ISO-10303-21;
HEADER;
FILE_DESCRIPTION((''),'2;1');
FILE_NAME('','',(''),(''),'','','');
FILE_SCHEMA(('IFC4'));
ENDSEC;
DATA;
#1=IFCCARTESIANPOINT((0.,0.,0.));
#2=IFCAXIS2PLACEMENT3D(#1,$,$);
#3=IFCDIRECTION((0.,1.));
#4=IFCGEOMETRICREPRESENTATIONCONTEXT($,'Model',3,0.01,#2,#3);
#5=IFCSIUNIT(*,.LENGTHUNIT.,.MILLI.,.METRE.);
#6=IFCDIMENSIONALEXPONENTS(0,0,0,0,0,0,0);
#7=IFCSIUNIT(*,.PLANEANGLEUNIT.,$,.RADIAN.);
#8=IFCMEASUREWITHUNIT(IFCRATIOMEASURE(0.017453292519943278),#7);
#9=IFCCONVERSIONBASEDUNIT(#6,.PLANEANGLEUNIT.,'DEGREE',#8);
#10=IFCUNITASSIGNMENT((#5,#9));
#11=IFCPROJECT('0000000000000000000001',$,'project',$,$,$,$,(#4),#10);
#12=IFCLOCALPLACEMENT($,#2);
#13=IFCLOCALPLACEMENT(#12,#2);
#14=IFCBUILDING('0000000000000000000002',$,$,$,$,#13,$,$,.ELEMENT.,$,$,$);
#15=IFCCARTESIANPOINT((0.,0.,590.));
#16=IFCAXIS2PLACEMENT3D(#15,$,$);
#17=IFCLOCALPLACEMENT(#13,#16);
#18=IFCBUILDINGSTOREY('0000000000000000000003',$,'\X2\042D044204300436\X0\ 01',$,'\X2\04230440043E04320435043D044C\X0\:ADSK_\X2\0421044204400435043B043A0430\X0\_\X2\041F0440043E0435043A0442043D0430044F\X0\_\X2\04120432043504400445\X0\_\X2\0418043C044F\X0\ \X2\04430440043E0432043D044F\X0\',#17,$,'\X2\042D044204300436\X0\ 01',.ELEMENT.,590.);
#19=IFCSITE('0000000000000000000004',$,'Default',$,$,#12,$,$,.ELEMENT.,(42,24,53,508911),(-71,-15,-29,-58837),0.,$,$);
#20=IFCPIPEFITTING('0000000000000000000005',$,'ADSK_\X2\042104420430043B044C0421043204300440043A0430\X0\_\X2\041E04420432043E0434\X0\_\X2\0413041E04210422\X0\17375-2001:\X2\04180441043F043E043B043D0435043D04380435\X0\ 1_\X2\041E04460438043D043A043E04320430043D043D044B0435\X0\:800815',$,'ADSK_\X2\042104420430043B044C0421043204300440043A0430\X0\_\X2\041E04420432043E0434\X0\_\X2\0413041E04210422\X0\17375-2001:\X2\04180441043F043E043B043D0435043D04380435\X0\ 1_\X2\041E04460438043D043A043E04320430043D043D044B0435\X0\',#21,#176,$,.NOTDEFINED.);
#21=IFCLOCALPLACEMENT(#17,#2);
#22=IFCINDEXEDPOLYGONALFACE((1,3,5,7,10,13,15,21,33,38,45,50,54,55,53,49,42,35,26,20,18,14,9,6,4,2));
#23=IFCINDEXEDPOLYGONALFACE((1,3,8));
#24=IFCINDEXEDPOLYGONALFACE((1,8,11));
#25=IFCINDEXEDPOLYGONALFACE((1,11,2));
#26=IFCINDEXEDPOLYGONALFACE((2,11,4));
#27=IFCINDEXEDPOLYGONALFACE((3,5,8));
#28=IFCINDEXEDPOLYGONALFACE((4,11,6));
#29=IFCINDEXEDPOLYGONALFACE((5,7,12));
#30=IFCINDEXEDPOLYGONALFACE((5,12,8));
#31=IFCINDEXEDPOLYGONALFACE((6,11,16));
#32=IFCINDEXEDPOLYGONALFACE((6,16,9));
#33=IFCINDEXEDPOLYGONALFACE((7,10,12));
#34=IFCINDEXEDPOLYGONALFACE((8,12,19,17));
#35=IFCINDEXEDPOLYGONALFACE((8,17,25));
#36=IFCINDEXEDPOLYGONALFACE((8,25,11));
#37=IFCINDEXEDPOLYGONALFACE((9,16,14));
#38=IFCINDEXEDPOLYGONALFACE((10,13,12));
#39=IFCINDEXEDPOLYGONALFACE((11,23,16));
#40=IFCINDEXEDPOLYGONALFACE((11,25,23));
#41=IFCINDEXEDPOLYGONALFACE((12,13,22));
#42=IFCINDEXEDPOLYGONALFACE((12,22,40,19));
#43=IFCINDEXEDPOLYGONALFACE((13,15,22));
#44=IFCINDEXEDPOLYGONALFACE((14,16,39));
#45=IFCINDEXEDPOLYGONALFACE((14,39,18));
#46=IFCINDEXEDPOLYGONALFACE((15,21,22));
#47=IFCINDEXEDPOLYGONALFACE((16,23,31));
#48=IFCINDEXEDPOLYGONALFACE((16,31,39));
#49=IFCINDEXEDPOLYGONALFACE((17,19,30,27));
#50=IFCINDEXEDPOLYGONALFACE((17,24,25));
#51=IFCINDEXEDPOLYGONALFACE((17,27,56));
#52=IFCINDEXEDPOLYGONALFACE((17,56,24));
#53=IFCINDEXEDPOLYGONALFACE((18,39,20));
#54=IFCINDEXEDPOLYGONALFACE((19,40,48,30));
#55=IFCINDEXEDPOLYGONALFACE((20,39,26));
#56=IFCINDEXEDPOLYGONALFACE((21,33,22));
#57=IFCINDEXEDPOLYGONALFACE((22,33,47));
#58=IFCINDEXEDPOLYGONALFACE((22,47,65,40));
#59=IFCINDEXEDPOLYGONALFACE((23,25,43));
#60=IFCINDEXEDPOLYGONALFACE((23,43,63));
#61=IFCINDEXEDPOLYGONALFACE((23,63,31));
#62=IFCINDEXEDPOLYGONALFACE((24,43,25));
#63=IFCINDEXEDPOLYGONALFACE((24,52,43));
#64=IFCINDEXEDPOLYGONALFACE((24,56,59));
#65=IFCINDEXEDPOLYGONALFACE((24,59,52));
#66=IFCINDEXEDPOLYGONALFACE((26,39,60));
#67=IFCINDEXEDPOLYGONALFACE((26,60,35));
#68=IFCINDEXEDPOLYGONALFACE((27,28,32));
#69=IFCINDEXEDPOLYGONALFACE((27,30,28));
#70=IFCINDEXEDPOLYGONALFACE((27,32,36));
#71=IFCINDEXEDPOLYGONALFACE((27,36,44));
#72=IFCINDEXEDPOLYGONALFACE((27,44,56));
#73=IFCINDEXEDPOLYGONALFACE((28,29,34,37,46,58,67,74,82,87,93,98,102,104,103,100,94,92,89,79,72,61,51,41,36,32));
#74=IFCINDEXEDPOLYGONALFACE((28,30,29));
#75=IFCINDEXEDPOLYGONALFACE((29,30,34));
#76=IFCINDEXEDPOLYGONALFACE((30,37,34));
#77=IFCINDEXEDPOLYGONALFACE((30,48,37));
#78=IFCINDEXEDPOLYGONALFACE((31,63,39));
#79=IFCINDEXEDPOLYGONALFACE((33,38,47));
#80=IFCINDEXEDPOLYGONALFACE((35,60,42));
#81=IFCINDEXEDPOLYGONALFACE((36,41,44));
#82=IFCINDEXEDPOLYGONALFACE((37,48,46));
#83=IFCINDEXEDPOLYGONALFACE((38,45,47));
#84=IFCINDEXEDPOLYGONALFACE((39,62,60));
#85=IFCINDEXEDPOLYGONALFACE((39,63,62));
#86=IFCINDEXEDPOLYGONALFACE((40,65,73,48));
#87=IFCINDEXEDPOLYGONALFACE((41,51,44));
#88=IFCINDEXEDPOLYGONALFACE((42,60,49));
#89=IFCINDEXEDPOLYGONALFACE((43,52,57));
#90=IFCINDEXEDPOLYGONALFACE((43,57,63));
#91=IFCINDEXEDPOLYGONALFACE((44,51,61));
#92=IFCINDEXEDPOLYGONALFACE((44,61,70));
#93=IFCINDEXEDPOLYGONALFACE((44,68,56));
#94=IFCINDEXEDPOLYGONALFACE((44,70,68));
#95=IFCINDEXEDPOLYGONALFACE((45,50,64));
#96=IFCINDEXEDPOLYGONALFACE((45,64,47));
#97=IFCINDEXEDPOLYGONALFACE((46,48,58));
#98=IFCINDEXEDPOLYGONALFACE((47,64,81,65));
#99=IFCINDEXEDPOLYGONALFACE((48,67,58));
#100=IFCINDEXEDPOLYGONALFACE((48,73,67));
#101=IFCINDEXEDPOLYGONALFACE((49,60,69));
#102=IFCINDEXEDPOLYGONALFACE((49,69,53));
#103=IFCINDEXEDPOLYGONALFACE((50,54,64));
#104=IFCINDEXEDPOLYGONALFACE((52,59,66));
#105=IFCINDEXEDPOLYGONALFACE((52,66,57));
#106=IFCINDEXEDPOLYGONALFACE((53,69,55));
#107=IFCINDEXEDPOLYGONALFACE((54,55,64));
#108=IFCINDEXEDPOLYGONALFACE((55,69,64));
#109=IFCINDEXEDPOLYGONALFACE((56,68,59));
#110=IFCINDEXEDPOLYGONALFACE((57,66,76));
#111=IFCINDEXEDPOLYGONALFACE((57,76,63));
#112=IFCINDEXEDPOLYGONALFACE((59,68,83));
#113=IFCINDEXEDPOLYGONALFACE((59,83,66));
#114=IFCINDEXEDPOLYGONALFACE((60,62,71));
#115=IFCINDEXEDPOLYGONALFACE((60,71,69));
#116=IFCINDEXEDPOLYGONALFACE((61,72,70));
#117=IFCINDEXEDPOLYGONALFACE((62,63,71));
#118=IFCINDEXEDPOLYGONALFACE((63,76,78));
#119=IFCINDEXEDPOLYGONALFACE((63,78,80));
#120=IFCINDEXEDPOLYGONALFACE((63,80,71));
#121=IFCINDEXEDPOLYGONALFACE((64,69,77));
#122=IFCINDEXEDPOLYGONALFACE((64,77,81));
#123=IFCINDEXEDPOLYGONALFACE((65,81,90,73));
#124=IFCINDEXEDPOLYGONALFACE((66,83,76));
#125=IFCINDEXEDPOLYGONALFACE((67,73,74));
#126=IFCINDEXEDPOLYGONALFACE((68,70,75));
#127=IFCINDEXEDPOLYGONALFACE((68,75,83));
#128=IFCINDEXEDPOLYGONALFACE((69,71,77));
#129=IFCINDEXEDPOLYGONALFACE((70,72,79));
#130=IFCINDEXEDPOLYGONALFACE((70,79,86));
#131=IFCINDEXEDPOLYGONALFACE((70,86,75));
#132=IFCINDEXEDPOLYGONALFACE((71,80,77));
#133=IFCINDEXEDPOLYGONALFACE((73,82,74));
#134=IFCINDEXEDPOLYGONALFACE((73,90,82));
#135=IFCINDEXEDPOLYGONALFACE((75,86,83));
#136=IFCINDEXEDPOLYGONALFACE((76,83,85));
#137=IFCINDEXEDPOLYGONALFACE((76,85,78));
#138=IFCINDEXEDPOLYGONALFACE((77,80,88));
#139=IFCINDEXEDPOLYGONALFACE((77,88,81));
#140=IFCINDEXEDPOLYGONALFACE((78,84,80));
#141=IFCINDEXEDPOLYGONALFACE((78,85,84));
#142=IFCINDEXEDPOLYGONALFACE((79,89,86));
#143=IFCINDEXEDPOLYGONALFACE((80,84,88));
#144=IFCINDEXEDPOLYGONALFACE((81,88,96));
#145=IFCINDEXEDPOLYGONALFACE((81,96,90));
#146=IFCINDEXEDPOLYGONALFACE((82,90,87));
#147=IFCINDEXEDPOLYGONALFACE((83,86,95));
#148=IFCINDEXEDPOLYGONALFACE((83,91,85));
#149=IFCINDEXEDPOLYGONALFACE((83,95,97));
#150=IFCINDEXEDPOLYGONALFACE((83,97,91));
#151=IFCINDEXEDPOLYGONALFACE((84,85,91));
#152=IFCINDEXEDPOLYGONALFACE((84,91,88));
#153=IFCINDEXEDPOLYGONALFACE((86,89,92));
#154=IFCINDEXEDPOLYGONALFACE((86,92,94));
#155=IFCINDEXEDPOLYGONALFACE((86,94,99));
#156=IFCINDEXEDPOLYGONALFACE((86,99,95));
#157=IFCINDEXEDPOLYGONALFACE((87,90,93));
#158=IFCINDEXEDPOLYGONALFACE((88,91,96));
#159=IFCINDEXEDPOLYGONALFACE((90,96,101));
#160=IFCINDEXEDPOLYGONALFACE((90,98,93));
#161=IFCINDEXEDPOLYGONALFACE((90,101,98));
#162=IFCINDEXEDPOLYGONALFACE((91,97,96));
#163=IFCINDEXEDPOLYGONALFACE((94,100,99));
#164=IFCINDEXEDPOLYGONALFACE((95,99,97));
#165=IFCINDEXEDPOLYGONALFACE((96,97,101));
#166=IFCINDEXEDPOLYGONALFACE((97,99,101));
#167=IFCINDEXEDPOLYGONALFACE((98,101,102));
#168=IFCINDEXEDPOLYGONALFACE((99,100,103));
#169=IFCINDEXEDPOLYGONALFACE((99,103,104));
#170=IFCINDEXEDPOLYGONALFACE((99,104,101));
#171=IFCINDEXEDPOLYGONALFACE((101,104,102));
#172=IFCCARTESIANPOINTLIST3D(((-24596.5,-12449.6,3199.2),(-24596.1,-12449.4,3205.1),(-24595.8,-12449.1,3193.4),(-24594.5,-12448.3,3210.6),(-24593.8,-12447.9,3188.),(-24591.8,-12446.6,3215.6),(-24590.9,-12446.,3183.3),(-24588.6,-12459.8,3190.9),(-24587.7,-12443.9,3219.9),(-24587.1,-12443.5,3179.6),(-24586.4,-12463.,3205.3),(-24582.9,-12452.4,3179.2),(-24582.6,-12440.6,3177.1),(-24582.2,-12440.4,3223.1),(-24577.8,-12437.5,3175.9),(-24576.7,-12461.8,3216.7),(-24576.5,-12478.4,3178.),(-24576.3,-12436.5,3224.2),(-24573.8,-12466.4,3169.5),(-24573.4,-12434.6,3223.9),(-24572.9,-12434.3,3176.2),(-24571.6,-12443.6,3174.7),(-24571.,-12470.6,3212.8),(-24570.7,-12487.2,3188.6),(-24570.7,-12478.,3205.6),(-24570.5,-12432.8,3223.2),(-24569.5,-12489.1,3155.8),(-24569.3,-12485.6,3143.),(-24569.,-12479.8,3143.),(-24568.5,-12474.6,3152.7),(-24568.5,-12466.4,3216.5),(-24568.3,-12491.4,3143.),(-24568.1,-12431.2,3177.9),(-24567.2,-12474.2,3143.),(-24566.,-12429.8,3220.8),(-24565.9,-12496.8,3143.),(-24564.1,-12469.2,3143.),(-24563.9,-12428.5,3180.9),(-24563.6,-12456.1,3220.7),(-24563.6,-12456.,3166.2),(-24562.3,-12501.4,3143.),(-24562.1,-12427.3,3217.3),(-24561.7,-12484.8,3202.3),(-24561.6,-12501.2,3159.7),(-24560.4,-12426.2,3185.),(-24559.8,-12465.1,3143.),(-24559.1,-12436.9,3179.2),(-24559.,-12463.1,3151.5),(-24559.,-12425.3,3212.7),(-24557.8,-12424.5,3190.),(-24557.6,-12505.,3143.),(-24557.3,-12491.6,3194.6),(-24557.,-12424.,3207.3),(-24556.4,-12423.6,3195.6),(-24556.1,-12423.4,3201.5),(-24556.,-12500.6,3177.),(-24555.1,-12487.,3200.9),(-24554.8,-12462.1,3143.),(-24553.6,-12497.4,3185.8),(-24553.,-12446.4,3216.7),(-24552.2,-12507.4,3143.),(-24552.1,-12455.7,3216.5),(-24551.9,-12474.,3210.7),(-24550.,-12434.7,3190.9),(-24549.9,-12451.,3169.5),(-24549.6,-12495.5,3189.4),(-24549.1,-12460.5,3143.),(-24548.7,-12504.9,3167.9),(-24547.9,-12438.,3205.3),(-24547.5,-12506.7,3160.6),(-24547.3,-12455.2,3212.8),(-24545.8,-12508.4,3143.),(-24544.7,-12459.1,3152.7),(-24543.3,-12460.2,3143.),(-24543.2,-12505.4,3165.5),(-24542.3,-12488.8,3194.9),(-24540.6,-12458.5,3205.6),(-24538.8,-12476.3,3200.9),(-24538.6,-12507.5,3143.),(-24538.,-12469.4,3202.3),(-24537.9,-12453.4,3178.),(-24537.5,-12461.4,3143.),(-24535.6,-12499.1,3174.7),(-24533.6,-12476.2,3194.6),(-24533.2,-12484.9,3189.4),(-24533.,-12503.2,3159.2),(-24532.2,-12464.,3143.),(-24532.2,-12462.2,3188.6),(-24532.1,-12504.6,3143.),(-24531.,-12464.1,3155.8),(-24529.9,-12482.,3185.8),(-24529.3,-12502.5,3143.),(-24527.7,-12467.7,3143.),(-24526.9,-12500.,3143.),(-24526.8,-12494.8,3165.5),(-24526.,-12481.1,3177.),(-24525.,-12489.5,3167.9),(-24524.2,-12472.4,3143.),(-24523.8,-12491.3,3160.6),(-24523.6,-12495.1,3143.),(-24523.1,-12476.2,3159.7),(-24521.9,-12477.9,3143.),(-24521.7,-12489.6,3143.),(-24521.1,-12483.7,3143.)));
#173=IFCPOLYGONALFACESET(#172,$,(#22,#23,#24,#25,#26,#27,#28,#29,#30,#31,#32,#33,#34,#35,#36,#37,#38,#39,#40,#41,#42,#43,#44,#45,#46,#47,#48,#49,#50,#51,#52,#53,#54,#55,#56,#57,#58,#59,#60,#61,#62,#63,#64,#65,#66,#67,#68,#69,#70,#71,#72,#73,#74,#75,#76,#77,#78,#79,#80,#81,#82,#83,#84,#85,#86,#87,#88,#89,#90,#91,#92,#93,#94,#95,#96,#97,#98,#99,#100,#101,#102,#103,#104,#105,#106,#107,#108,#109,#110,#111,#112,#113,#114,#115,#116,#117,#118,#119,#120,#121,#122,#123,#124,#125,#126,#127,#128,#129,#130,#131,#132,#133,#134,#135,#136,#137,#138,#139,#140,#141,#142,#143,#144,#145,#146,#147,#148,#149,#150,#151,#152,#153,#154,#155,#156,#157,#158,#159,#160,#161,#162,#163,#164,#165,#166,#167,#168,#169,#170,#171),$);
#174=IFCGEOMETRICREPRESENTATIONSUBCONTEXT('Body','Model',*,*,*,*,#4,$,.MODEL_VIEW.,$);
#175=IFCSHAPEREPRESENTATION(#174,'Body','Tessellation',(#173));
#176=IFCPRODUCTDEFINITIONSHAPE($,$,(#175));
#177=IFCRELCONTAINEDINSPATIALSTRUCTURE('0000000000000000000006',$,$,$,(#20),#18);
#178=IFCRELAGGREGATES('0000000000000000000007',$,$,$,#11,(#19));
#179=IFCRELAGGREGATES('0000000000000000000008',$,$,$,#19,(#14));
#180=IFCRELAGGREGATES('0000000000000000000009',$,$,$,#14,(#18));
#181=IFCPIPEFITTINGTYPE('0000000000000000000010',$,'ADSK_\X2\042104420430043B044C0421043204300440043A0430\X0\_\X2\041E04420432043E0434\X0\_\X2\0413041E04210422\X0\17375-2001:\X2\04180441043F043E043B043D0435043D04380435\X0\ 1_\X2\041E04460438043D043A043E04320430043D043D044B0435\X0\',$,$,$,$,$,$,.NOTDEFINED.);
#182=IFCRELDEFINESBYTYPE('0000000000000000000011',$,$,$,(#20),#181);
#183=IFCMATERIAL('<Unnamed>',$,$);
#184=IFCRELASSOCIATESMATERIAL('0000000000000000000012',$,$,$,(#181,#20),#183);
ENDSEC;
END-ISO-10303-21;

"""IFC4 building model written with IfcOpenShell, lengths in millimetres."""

from ifc_helpers import new_model, entity, si_unit, converted_unit, direction, frame, origin, place, context, subcontext, project, spatial, source, transform, mapped, material, type_object, type_shapes, element, save


model = new_model("IFC4")

# Units and contexts
model_context = context("Model", 3, precision=0.01, world=origin(), true_north=direction((0.0, 1.0)))
body_context = subcontext(model_context, "Body", "Model", "MODEL_VIEW")
ifc_project = project(units=[si_unit("LENGTHUNIT", "METRE", prefix="MILLI"), converted_unit("PLANEANGLEUNIT", "DEGREE", entity("IfcRatioMeasure", 0.017453292519943278), si_unit("PLANEANGLEUNIT", "RADIAN"), dimensions=[0, 0, 0, 0, 0, 0, 0])], contexts=[model_context])

# Site, building, storey
site_placement = place(None, origin())
site = spatial("IfcSite", under=ifc_project, at=site_placement, Name="Default", CompositionType="ELEMENT", RefLatitude=(42, 24, 53, 508911), RefLongitude=(-71, -15, -29, -58837), RefElevation=0.0)
building_placement = place(site_placement, origin())
building = spatial("IfcBuilding", under=site, at=building_placement, CompositionType="ELEMENT")
storey_placement = place(building_placement, frame((0.0, 0.0, 590.0)))
storey = spatial("IfcBuildingStorey", under=building, at=storey_placement, Name="Этаж 01", ObjectType="Уровень:ADSK_Стрелка_Проектная_Вверх_Имя уровня", LongName="Этаж 01", CompositionType="ELEMENT", Elevation=590.0)

# Shared definitions
ifc_material_1 = material(Name="<Unnamed>")

# Pipe fitting
pipe_fitting_type = type_object("IfcPipeFittingType", Name="ADSK_СтальСварка_Отвод_ГОСТ17375-2001:Исполнение 1_Оцинкованные", PredefinedType="NOTDEFINED", material=ifc_material_1)
ifc_direction = entity("IfcDirection", [0.0, 0.0, 1.0])
trimmed_curve = entity("IfcTrimmedCurve", entity("IfcCircle", entity("IfcAxis2Placement2D", entity("IfcCartesianPoint", [-57.0, 0.0]), entity("IfcDirection", [0.0, 1.0])), 57.0), [entity("IfcParameterValue", 270.0)], [entity("IfcParameterValue", 0.0)], True, "PARAMETER")
shared_shape_1 = source(origin(), body_context, "Body", "AdvancedSweptSolid", [
    entity("IfcSurfaceCurveSweptAreaSolid", entity("IfcCircleProfileDef", "AREA", None, entity("IfcAxis2Placement2D", entity("IfcCartesianPoint", [0.0, 0.0]), entity("IfcDirection", [1.0, 0.0])), 24.1), entity("IfcAxis2Placement3D", entity("IfcCartesianPoint", [-57.0, 0.0, 0.0]), ifc_direction, entity("IfcDirection", [0.0, -1.0, 0.0])), trimmed_curve, 0.0, 90.0, entity("IfcSurfaceOfLinearExtrusion", entity("IfcArbitraryOpenProfileDef", "CURVE", None, trimmed_curve), entity("IfcAxis2Placement3D", entity("IfcCartesianPoint", [0.0, 0.0, -304.8])), ifc_direction, 1.0)),
])
type_shapes(pipe_fitting_type, [shared_shape_1])
for number, where, z_axis, x_axis, name in (
    (1, (-24545.2, -12484.3, 3200.0), (0.838671, 0.544639, 0.0), (0.544639, -0.838671, 0.0), "ADSK_СтальСварка_Отвод_ГОСТ17375-2001:Исполнение 1_Оцинкованные:800815"),
):
    element("IfcPipeFitting", number, at=place(storey_placement, frame(where, z_axis=z_axis, x_axis=x_axis)), inside=storey, type_object=pipe_fitting_type, material=ifc_material_1, Name=name, ObjectType="ADSK_СтальСварка_Отвод_ГОСТ17375-2001:Исполнение 1_Оцинкованные", PredefinedType="NOTDEFINED", context=body_context, shape_type="MappedRepresentation", body=[
        mapped(shared_shape_1, transform((0.0, 0.0, 0.0), scale=1.0)),
    ])

save(model, "model.ifc")
